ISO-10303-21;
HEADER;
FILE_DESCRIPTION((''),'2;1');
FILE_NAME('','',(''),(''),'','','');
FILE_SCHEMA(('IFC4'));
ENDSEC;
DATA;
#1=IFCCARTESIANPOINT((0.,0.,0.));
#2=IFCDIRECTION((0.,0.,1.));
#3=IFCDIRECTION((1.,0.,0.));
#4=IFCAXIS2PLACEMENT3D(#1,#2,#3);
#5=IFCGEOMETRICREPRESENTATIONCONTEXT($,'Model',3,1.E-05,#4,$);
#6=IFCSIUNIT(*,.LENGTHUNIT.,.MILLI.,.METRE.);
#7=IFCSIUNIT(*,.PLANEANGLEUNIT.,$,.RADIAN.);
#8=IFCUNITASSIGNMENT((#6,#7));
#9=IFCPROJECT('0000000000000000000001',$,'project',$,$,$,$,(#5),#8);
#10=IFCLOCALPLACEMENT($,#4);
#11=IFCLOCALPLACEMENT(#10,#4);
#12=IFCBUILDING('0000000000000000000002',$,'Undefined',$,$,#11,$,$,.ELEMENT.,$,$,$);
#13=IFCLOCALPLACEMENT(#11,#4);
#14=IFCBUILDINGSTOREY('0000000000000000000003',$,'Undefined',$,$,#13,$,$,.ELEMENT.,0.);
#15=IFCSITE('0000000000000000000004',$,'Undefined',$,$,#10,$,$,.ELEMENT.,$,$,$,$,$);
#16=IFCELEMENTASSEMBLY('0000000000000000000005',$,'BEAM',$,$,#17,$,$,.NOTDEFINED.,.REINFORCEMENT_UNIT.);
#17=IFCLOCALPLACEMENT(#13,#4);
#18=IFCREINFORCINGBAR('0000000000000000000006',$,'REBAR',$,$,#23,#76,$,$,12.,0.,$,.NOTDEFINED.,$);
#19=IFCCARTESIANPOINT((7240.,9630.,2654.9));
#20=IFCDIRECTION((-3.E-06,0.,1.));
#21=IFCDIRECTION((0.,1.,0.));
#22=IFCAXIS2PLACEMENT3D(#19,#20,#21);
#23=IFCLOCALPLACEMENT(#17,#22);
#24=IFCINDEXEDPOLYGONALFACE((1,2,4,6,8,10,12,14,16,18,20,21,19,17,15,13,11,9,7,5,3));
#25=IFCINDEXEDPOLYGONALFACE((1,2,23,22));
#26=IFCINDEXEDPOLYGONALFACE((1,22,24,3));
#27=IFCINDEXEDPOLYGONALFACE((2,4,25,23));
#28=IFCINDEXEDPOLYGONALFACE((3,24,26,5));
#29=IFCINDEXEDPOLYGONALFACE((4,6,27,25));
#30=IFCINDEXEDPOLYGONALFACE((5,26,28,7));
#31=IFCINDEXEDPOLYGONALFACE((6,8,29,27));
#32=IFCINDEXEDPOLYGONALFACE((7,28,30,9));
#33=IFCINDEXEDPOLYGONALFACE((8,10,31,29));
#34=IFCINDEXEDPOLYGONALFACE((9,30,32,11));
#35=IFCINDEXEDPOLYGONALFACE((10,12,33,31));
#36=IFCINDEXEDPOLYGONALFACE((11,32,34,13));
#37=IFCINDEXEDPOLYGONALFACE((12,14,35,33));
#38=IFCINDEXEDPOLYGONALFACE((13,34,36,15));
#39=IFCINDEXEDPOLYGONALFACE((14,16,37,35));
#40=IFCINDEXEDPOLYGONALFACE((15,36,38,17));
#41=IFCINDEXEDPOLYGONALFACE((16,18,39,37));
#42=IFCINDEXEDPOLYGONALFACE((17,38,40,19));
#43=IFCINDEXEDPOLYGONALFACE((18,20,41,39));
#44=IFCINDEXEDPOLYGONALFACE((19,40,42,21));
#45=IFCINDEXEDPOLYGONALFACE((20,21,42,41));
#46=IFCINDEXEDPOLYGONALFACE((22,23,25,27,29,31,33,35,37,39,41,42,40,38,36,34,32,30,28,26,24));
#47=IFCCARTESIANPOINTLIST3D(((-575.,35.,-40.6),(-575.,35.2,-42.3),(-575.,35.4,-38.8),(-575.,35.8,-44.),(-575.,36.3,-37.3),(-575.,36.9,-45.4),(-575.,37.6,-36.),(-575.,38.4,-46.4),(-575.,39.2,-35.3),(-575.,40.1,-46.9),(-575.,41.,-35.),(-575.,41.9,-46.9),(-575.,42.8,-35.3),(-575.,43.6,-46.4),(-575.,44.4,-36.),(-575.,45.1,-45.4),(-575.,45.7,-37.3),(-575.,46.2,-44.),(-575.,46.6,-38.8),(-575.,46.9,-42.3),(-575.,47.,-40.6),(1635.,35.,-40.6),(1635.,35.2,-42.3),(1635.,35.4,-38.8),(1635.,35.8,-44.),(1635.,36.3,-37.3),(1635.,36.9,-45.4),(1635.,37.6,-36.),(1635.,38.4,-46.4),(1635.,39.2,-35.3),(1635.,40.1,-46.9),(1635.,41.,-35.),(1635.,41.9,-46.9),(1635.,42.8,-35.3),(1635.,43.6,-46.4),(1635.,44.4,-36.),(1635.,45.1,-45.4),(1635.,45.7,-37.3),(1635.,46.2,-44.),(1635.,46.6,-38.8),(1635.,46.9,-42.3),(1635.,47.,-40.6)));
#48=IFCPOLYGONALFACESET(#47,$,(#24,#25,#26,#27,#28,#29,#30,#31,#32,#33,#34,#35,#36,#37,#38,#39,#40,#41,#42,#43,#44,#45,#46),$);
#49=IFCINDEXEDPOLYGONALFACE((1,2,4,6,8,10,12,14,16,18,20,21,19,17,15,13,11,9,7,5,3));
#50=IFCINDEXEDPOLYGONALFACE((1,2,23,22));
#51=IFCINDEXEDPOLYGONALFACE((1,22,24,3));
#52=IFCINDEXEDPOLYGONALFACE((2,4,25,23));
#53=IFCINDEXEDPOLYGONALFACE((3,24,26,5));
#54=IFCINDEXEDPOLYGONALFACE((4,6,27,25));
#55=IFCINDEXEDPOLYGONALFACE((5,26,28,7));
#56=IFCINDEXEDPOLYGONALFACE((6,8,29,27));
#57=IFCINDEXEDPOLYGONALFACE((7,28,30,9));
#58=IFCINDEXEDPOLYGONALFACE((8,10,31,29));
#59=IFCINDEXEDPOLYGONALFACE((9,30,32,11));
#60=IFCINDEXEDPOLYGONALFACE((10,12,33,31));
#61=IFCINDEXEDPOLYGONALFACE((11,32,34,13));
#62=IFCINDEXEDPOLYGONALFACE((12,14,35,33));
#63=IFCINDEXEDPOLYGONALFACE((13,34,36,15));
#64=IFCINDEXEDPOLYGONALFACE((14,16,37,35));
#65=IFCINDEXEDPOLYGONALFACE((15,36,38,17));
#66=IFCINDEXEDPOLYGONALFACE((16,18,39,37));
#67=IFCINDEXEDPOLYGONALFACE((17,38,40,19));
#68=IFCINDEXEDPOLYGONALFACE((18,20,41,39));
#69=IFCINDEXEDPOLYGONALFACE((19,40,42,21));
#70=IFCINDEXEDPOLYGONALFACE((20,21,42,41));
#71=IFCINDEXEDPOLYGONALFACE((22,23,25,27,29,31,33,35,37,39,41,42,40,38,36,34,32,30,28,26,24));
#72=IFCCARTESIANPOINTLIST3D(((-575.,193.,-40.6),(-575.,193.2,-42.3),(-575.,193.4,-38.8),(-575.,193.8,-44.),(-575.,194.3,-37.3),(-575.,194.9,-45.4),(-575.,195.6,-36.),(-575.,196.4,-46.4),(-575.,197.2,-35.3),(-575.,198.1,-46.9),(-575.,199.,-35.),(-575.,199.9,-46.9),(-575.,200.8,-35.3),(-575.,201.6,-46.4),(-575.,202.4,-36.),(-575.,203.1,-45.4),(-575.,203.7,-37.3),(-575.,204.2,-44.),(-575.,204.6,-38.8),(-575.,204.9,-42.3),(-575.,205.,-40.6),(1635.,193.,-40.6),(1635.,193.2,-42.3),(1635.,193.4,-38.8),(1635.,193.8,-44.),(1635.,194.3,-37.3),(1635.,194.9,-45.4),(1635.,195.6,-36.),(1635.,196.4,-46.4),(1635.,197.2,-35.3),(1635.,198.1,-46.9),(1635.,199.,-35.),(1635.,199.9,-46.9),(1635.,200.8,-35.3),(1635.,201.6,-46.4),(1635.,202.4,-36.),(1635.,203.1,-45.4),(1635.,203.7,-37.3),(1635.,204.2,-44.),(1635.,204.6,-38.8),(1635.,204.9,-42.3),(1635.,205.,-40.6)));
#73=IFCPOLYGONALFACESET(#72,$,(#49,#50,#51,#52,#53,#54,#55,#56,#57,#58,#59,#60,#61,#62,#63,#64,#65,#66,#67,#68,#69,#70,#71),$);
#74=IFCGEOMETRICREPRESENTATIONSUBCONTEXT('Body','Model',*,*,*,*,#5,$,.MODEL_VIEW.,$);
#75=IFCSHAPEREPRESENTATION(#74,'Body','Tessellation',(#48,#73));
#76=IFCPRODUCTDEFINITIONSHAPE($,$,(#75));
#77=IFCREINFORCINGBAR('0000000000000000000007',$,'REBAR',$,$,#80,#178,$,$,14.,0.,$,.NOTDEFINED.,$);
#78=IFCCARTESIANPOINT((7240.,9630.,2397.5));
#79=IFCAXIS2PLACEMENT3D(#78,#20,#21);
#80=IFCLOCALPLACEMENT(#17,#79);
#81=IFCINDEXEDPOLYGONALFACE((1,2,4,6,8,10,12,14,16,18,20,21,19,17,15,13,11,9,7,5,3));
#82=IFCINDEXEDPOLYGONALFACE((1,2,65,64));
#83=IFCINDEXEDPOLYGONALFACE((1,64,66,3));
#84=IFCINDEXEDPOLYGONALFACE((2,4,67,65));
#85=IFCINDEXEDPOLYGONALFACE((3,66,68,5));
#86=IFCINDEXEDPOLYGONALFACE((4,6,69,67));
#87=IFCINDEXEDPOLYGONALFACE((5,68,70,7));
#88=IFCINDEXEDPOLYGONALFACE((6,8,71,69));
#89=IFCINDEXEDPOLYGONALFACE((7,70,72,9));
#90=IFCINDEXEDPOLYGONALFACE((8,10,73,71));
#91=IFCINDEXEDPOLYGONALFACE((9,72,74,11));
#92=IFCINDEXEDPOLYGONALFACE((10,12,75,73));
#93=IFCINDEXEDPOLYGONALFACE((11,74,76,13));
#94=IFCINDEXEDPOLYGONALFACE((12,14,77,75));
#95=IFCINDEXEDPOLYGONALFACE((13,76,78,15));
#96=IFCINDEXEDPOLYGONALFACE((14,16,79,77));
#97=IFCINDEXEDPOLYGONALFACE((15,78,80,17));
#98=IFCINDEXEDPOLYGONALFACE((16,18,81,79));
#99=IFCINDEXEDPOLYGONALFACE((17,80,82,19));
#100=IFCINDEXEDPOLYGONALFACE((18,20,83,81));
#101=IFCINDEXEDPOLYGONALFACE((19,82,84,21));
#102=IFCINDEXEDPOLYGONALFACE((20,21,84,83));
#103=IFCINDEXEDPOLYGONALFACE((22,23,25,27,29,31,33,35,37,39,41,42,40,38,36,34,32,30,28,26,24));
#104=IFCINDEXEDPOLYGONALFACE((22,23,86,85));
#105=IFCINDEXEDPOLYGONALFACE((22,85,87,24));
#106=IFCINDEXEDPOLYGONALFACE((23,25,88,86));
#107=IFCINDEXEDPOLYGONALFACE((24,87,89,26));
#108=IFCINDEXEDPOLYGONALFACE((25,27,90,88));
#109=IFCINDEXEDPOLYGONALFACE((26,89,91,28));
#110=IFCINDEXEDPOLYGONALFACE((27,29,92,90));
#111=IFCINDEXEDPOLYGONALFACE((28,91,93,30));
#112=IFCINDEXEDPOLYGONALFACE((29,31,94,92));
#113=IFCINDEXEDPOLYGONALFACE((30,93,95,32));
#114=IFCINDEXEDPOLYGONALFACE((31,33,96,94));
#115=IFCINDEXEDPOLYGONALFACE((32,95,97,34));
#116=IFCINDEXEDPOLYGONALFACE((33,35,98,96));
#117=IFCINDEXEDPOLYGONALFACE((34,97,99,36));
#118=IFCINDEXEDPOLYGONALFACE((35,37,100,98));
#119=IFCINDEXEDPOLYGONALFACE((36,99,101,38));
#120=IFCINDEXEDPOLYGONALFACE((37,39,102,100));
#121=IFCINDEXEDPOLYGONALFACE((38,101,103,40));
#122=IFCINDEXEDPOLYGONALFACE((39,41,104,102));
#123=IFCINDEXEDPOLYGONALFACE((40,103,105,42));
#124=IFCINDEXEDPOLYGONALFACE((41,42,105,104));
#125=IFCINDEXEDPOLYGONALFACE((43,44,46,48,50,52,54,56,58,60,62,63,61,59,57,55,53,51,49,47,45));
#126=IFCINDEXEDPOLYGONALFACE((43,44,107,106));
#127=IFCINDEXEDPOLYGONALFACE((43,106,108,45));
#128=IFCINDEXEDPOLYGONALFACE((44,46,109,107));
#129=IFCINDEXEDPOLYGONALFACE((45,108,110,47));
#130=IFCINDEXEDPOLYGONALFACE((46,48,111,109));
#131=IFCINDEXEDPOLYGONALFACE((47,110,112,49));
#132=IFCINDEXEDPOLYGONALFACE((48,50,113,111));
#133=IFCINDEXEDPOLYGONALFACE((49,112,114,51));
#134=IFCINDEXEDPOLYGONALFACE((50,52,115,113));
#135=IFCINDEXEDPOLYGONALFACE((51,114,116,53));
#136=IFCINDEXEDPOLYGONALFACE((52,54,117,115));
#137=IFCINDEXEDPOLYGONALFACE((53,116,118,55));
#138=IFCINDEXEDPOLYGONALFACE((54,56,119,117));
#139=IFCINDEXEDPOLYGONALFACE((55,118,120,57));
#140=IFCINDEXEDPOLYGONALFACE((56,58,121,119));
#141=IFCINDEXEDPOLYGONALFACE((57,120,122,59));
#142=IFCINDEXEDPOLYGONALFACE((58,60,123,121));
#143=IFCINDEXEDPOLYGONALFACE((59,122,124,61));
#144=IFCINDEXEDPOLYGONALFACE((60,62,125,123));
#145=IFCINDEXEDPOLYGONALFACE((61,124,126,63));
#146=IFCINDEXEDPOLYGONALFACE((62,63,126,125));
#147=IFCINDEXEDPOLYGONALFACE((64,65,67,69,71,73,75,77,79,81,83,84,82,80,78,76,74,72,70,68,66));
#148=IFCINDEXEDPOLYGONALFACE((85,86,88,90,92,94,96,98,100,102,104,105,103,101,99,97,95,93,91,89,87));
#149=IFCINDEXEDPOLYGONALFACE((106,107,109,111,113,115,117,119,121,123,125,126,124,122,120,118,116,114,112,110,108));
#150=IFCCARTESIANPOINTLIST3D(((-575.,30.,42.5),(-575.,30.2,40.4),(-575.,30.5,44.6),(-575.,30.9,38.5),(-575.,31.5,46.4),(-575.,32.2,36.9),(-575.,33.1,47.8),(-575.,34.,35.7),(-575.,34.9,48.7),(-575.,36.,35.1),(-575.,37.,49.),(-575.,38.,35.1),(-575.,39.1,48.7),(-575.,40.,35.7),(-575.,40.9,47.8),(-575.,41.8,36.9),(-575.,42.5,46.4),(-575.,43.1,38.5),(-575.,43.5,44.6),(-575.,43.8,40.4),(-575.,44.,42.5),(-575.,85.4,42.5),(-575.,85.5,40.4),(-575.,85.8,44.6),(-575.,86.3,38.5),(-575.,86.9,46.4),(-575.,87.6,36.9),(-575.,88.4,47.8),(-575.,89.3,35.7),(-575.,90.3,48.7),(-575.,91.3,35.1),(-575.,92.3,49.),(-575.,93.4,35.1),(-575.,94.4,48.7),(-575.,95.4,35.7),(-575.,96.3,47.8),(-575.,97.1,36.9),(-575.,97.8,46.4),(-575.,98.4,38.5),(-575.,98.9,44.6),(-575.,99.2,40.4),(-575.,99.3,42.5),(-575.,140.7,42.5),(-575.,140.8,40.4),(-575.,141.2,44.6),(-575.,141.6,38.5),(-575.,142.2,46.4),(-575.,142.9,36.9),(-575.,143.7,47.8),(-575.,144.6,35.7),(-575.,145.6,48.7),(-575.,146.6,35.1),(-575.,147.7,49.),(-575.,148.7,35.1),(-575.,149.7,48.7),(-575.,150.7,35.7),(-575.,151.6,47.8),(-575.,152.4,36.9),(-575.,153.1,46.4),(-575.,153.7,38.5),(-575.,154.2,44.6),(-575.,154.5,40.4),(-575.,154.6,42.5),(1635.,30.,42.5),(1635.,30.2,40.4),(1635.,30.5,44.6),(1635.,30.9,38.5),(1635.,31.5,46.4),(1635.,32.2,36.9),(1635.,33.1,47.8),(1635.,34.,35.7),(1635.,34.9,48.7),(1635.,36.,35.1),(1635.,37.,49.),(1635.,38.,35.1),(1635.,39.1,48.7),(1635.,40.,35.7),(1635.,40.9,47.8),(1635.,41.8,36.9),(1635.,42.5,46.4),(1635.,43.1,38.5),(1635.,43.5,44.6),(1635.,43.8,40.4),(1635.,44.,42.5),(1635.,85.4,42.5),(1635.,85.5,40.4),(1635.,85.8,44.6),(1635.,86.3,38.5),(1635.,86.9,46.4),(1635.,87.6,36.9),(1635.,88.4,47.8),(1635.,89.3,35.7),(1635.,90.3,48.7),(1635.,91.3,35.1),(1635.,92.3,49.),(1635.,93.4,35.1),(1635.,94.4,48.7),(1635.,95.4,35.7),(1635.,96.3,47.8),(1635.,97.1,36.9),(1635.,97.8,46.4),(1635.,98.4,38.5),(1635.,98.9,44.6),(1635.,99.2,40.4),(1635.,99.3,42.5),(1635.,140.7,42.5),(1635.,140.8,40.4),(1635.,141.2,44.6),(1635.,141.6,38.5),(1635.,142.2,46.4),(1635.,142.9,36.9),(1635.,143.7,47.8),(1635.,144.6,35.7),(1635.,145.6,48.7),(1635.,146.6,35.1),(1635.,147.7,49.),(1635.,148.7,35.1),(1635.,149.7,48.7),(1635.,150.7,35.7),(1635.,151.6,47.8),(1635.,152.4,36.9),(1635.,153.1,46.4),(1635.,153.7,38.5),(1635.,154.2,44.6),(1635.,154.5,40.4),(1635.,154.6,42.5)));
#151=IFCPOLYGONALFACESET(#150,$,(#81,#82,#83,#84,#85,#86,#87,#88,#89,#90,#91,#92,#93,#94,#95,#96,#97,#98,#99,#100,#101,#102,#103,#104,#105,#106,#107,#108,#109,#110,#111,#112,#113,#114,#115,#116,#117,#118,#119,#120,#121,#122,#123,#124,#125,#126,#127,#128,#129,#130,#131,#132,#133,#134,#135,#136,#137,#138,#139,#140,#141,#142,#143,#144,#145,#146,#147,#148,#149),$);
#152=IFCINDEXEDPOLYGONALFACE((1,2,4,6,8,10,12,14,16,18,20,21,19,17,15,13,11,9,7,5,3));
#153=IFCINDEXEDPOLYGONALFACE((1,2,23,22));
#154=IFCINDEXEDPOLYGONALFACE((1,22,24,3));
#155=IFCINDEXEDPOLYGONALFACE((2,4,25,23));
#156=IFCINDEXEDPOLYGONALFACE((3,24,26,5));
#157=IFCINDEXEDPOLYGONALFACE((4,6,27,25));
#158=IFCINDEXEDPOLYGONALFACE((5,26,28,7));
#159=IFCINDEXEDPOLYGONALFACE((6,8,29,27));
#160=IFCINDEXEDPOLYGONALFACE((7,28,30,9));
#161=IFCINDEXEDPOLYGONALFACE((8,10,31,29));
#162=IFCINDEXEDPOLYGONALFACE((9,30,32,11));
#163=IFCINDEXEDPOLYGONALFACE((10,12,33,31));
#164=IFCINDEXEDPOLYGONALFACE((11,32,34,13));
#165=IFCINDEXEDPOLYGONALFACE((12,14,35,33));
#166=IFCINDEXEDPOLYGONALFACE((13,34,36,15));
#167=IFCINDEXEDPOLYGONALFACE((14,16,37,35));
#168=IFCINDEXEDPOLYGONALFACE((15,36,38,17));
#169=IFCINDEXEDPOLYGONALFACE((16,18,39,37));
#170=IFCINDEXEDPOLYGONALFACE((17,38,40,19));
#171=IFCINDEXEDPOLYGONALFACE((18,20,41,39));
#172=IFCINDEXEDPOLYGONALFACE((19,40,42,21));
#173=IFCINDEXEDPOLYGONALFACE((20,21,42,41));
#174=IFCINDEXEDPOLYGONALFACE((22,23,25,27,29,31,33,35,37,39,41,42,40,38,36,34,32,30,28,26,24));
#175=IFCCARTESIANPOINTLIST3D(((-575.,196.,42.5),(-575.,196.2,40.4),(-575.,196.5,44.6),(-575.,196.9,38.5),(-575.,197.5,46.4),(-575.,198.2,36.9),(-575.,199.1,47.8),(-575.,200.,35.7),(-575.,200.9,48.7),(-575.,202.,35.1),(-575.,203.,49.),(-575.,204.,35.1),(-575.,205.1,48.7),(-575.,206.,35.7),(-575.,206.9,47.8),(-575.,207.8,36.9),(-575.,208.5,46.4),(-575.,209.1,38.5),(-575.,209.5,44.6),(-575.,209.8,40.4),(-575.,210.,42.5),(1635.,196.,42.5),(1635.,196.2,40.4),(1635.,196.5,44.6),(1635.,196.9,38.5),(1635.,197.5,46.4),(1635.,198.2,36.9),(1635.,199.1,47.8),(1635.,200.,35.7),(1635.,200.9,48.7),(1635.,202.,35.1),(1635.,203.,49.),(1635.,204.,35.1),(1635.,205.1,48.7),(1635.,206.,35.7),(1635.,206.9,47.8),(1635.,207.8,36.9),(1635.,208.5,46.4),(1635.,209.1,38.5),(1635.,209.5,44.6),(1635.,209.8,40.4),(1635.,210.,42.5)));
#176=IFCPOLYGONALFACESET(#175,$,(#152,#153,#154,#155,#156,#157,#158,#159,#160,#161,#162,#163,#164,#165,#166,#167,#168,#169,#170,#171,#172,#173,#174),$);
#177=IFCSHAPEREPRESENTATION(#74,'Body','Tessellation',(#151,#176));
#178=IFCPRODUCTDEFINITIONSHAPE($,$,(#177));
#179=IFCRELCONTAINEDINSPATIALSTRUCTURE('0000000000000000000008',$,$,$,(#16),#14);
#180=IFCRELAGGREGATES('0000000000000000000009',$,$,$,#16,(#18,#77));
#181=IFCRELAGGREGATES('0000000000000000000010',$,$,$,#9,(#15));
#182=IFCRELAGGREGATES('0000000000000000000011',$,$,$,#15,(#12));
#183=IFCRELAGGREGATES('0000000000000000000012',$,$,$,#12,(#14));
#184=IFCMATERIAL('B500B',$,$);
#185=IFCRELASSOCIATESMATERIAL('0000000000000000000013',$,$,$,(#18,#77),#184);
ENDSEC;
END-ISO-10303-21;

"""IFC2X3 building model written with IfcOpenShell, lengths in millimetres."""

from ifc_helpers import new_model, entity, si_unit, frame, origin_with_axes, place, context, subcontext, project, spatial, source, transform, mapped, material, element, aggregate, save


model = new_model("IFC2X3")

# Units and contexts
model_context = context("Model", 3, precision=1e-05, world=origin_with_axes())
body_context = subcontext(model_context, "Body", "Model", "MODEL_VIEW")
ifc_project = project(units=[si_unit("LENGTHUNIT", "METRE", prefix="MILLI"), si_unit("PLANEANGLEUNIT", "RADIAN")], contexts=[model_context])

# Site, building, storey
site_placement = place(None, origin_with_axes())
site = spatial("IfcSite", under=ifc_project, at=site_placement, Name="Undefined", CompositionType="ELEMENT")
building_placement = place(site_placement, origin_with_axes())
building = spatial("IfcBuilding", under=site, at=building_placement, Name="Undefined", CompositionType="ELEMENT")
storey_placement = place(building_placement, origin_with_axes())
storey = spatial("IfcBuildingStorey", under=building, at=storey_placement, Name="Undefined", CompositionType="ELEMENT", Elevation=0.0)

# Element assembly, reinforcing bars
ifc_material_1 = material(Name="B500B")
assembly_1_placement = place(storey_placement, origin_with_axes())
assembly_1 = element("IfcElementAssembly", 1, at=assembly_1_placement, inside=storey, Name="BEAM", AssemblyPlace="NOTDEFINED", PredefinedType="REINFORCEMENT_UNIT")
shared_shape_1 = source(origin_with_axes(), body_context, "Body", "AdvancedSweptSolid", [
    entity("IfcSweptDiskSolid", entity("IfcTrimmedCurve", entity("IfcLine", entity("IfcCartesianPoint", [0.0, 0.0, 0.0]), entity("IfcVector", entity("IfcDirection", [1.0, 0.0, 0.0]), 1.0)), [entity("IfcParameterValue", 0.0)], [entity("IfcParameterValue", 2209.999613)], True, "PARAMETER"), 6.0, None, 0.0, 2210.0),
])
shared_shape_2 = source(origin_with_axes(), body_context, "Body", "AdvancedSweptSolid", [
    entity("IfcSweptDiskSolid", entity("IfcTrimmedCurve", entity("IfcLine", entity("IfcCartesianPoint", [0.0, 0.0, 0.0]), entity("IfcVector", entity("IfcDirection", [1.0, 0.0, 0.0]), 1.0)), [entity("IfcParameterValue", 0.0)], [entity("IfcParameterValue", 2209.999613)], True, "PARAMETER"), 6.0, None, 0.0, 2210.0),
])
reinforcing_bar_1_placement = place(assembly_1_placement, frame((7240.0, 9630.0, 2654.9), z_axis=(-0.000003, 0.0, 1.0), x_axis=(0.0, 1.0, 0.0)))
reinforcing_bar_1 = element("IfcReinforcingBar", 2, at=reinforcing_bar_1_placement, material=ifc_material_1, Name="REBAR", BarRole="NOTDEFINED", CrossSectionArea=0.0, NominalDiameter=12.0, context=body_context, shape_type="MappedRepresentation", body=[
    mapped(shared_shape_1, transform((-575.0, 41.0, -41.0))),
    mapped(shared_shape_2, transform((-575.0, 199.0, -41.0))),
])
shared_shape_3 = source(origin_with_axes(), body_context, "Body", "AdvancedSweptSolid", [
    entity("IfcSweptDiskSolid", entity("IfcTrimmedCurve", entity("IfcLine", entity("IfcCartesianPoint", [0.0, 0.0, 0.0]), entity("IfcVector", entity("IfcDirection", [1.0, 0.0, 0.0]), 1.0)), [entity("IfcParameterValue", 0.0)], [entity("IfcParameterValue", 2209.999613)], True, "PARAMETER"), 7.0, None, 0.0, 2210.0),
])
shared_shape_4 = source(origin_with_axes(), body_context, "Body", "AdvancedSweptSolid", [
    entity("IfcSweptDiskSolid", entity("IfcTrimmedCurve", entity("IfcLine", entity("IfcCartesianPoint", [0.0, 0.0, 0.0]), entity("IfcVector", entity("IfcDirection", [1.0, 0.0, 0.0]), 1.0)), [entity("IfcParameterValue", 0.0)], [entity("IfcParameterValue", 2209.999613)], True, "PARAMETER"), 7.0, None, 0.0, 2210.0),
])
shared_shape_5 = source(origin_with_axes(), body_context, "Body", "AdvancedSweptSolid", [
    entity("IfcSweptDiskSolid", entity("IfcTrimmedCurve", entity("IfcLine", entity("IfcCartesianPoint", [0.0, 0.0, 0.0]), entity("IfcVector", entity("IfcDirection", [1.0, 0.0, 0.0]), 1.0)), [entity("IfcParameterValue", 0.0)], [entity("IfcParameterValue", 2209.999613)], True, "PARAMETER"), 7.0, None, 0.0, 2210.0),
])
shared_shape_6 = source(origin_with_axes(), body_context, "Body", "AdvancedSweptSolid", [
    entity("IfcSweptDiskSolid", entity("IfcTrimmedCurve", entity("IfcLine", entity("IfcCartesianPoint", [0.0, 0.0, 0.0]), entity("IfcVector", entity("IfcDirection", [1.0, 0.0, 0.0]), 1.0)), [entity("IfcParameterValue", 0.0)], [entity("IfcParameterValue", 2209.999613)], True, "PARAMETER"), 7.0, None, 0.0, 2210.0),
])
reinforcing_bar_2_placement = place(assembly_1_placement, frame((7240.0, 9630.0, 2397.5), z_axis=(-0.000003, 0.0, 1.0), x_axis=(0.0, 1.0, 0.0)))
reinforcing_bar_2 = element("IfcReinforcingBar", 3, at=reinforcing_bar_2_placement, material=ifc_material_1, Name="REBAR", BarRole="NOTDEFINED", CrossSectionArea=0.0, NominalDiameter=14.0, context=body_context, shape_type="MappedRepresentation", body=[
    mapped(shared_shape_3, transform((-575.0, 37.0, 42.0))),
    mapped(shared_shape_4, transform((-575.0, 92.3, 42.0))),
    mapped(shared_shape_5, transform((-575.0, 147.7, 42.0))),
    mapped(shared_shape_6, transform((-575.0, 203.0, 42.0))),
])
aggregate(assembly_1, [reinforcing_bar_1, reinforcing_bar_2])

save(model, "model.ifc")
